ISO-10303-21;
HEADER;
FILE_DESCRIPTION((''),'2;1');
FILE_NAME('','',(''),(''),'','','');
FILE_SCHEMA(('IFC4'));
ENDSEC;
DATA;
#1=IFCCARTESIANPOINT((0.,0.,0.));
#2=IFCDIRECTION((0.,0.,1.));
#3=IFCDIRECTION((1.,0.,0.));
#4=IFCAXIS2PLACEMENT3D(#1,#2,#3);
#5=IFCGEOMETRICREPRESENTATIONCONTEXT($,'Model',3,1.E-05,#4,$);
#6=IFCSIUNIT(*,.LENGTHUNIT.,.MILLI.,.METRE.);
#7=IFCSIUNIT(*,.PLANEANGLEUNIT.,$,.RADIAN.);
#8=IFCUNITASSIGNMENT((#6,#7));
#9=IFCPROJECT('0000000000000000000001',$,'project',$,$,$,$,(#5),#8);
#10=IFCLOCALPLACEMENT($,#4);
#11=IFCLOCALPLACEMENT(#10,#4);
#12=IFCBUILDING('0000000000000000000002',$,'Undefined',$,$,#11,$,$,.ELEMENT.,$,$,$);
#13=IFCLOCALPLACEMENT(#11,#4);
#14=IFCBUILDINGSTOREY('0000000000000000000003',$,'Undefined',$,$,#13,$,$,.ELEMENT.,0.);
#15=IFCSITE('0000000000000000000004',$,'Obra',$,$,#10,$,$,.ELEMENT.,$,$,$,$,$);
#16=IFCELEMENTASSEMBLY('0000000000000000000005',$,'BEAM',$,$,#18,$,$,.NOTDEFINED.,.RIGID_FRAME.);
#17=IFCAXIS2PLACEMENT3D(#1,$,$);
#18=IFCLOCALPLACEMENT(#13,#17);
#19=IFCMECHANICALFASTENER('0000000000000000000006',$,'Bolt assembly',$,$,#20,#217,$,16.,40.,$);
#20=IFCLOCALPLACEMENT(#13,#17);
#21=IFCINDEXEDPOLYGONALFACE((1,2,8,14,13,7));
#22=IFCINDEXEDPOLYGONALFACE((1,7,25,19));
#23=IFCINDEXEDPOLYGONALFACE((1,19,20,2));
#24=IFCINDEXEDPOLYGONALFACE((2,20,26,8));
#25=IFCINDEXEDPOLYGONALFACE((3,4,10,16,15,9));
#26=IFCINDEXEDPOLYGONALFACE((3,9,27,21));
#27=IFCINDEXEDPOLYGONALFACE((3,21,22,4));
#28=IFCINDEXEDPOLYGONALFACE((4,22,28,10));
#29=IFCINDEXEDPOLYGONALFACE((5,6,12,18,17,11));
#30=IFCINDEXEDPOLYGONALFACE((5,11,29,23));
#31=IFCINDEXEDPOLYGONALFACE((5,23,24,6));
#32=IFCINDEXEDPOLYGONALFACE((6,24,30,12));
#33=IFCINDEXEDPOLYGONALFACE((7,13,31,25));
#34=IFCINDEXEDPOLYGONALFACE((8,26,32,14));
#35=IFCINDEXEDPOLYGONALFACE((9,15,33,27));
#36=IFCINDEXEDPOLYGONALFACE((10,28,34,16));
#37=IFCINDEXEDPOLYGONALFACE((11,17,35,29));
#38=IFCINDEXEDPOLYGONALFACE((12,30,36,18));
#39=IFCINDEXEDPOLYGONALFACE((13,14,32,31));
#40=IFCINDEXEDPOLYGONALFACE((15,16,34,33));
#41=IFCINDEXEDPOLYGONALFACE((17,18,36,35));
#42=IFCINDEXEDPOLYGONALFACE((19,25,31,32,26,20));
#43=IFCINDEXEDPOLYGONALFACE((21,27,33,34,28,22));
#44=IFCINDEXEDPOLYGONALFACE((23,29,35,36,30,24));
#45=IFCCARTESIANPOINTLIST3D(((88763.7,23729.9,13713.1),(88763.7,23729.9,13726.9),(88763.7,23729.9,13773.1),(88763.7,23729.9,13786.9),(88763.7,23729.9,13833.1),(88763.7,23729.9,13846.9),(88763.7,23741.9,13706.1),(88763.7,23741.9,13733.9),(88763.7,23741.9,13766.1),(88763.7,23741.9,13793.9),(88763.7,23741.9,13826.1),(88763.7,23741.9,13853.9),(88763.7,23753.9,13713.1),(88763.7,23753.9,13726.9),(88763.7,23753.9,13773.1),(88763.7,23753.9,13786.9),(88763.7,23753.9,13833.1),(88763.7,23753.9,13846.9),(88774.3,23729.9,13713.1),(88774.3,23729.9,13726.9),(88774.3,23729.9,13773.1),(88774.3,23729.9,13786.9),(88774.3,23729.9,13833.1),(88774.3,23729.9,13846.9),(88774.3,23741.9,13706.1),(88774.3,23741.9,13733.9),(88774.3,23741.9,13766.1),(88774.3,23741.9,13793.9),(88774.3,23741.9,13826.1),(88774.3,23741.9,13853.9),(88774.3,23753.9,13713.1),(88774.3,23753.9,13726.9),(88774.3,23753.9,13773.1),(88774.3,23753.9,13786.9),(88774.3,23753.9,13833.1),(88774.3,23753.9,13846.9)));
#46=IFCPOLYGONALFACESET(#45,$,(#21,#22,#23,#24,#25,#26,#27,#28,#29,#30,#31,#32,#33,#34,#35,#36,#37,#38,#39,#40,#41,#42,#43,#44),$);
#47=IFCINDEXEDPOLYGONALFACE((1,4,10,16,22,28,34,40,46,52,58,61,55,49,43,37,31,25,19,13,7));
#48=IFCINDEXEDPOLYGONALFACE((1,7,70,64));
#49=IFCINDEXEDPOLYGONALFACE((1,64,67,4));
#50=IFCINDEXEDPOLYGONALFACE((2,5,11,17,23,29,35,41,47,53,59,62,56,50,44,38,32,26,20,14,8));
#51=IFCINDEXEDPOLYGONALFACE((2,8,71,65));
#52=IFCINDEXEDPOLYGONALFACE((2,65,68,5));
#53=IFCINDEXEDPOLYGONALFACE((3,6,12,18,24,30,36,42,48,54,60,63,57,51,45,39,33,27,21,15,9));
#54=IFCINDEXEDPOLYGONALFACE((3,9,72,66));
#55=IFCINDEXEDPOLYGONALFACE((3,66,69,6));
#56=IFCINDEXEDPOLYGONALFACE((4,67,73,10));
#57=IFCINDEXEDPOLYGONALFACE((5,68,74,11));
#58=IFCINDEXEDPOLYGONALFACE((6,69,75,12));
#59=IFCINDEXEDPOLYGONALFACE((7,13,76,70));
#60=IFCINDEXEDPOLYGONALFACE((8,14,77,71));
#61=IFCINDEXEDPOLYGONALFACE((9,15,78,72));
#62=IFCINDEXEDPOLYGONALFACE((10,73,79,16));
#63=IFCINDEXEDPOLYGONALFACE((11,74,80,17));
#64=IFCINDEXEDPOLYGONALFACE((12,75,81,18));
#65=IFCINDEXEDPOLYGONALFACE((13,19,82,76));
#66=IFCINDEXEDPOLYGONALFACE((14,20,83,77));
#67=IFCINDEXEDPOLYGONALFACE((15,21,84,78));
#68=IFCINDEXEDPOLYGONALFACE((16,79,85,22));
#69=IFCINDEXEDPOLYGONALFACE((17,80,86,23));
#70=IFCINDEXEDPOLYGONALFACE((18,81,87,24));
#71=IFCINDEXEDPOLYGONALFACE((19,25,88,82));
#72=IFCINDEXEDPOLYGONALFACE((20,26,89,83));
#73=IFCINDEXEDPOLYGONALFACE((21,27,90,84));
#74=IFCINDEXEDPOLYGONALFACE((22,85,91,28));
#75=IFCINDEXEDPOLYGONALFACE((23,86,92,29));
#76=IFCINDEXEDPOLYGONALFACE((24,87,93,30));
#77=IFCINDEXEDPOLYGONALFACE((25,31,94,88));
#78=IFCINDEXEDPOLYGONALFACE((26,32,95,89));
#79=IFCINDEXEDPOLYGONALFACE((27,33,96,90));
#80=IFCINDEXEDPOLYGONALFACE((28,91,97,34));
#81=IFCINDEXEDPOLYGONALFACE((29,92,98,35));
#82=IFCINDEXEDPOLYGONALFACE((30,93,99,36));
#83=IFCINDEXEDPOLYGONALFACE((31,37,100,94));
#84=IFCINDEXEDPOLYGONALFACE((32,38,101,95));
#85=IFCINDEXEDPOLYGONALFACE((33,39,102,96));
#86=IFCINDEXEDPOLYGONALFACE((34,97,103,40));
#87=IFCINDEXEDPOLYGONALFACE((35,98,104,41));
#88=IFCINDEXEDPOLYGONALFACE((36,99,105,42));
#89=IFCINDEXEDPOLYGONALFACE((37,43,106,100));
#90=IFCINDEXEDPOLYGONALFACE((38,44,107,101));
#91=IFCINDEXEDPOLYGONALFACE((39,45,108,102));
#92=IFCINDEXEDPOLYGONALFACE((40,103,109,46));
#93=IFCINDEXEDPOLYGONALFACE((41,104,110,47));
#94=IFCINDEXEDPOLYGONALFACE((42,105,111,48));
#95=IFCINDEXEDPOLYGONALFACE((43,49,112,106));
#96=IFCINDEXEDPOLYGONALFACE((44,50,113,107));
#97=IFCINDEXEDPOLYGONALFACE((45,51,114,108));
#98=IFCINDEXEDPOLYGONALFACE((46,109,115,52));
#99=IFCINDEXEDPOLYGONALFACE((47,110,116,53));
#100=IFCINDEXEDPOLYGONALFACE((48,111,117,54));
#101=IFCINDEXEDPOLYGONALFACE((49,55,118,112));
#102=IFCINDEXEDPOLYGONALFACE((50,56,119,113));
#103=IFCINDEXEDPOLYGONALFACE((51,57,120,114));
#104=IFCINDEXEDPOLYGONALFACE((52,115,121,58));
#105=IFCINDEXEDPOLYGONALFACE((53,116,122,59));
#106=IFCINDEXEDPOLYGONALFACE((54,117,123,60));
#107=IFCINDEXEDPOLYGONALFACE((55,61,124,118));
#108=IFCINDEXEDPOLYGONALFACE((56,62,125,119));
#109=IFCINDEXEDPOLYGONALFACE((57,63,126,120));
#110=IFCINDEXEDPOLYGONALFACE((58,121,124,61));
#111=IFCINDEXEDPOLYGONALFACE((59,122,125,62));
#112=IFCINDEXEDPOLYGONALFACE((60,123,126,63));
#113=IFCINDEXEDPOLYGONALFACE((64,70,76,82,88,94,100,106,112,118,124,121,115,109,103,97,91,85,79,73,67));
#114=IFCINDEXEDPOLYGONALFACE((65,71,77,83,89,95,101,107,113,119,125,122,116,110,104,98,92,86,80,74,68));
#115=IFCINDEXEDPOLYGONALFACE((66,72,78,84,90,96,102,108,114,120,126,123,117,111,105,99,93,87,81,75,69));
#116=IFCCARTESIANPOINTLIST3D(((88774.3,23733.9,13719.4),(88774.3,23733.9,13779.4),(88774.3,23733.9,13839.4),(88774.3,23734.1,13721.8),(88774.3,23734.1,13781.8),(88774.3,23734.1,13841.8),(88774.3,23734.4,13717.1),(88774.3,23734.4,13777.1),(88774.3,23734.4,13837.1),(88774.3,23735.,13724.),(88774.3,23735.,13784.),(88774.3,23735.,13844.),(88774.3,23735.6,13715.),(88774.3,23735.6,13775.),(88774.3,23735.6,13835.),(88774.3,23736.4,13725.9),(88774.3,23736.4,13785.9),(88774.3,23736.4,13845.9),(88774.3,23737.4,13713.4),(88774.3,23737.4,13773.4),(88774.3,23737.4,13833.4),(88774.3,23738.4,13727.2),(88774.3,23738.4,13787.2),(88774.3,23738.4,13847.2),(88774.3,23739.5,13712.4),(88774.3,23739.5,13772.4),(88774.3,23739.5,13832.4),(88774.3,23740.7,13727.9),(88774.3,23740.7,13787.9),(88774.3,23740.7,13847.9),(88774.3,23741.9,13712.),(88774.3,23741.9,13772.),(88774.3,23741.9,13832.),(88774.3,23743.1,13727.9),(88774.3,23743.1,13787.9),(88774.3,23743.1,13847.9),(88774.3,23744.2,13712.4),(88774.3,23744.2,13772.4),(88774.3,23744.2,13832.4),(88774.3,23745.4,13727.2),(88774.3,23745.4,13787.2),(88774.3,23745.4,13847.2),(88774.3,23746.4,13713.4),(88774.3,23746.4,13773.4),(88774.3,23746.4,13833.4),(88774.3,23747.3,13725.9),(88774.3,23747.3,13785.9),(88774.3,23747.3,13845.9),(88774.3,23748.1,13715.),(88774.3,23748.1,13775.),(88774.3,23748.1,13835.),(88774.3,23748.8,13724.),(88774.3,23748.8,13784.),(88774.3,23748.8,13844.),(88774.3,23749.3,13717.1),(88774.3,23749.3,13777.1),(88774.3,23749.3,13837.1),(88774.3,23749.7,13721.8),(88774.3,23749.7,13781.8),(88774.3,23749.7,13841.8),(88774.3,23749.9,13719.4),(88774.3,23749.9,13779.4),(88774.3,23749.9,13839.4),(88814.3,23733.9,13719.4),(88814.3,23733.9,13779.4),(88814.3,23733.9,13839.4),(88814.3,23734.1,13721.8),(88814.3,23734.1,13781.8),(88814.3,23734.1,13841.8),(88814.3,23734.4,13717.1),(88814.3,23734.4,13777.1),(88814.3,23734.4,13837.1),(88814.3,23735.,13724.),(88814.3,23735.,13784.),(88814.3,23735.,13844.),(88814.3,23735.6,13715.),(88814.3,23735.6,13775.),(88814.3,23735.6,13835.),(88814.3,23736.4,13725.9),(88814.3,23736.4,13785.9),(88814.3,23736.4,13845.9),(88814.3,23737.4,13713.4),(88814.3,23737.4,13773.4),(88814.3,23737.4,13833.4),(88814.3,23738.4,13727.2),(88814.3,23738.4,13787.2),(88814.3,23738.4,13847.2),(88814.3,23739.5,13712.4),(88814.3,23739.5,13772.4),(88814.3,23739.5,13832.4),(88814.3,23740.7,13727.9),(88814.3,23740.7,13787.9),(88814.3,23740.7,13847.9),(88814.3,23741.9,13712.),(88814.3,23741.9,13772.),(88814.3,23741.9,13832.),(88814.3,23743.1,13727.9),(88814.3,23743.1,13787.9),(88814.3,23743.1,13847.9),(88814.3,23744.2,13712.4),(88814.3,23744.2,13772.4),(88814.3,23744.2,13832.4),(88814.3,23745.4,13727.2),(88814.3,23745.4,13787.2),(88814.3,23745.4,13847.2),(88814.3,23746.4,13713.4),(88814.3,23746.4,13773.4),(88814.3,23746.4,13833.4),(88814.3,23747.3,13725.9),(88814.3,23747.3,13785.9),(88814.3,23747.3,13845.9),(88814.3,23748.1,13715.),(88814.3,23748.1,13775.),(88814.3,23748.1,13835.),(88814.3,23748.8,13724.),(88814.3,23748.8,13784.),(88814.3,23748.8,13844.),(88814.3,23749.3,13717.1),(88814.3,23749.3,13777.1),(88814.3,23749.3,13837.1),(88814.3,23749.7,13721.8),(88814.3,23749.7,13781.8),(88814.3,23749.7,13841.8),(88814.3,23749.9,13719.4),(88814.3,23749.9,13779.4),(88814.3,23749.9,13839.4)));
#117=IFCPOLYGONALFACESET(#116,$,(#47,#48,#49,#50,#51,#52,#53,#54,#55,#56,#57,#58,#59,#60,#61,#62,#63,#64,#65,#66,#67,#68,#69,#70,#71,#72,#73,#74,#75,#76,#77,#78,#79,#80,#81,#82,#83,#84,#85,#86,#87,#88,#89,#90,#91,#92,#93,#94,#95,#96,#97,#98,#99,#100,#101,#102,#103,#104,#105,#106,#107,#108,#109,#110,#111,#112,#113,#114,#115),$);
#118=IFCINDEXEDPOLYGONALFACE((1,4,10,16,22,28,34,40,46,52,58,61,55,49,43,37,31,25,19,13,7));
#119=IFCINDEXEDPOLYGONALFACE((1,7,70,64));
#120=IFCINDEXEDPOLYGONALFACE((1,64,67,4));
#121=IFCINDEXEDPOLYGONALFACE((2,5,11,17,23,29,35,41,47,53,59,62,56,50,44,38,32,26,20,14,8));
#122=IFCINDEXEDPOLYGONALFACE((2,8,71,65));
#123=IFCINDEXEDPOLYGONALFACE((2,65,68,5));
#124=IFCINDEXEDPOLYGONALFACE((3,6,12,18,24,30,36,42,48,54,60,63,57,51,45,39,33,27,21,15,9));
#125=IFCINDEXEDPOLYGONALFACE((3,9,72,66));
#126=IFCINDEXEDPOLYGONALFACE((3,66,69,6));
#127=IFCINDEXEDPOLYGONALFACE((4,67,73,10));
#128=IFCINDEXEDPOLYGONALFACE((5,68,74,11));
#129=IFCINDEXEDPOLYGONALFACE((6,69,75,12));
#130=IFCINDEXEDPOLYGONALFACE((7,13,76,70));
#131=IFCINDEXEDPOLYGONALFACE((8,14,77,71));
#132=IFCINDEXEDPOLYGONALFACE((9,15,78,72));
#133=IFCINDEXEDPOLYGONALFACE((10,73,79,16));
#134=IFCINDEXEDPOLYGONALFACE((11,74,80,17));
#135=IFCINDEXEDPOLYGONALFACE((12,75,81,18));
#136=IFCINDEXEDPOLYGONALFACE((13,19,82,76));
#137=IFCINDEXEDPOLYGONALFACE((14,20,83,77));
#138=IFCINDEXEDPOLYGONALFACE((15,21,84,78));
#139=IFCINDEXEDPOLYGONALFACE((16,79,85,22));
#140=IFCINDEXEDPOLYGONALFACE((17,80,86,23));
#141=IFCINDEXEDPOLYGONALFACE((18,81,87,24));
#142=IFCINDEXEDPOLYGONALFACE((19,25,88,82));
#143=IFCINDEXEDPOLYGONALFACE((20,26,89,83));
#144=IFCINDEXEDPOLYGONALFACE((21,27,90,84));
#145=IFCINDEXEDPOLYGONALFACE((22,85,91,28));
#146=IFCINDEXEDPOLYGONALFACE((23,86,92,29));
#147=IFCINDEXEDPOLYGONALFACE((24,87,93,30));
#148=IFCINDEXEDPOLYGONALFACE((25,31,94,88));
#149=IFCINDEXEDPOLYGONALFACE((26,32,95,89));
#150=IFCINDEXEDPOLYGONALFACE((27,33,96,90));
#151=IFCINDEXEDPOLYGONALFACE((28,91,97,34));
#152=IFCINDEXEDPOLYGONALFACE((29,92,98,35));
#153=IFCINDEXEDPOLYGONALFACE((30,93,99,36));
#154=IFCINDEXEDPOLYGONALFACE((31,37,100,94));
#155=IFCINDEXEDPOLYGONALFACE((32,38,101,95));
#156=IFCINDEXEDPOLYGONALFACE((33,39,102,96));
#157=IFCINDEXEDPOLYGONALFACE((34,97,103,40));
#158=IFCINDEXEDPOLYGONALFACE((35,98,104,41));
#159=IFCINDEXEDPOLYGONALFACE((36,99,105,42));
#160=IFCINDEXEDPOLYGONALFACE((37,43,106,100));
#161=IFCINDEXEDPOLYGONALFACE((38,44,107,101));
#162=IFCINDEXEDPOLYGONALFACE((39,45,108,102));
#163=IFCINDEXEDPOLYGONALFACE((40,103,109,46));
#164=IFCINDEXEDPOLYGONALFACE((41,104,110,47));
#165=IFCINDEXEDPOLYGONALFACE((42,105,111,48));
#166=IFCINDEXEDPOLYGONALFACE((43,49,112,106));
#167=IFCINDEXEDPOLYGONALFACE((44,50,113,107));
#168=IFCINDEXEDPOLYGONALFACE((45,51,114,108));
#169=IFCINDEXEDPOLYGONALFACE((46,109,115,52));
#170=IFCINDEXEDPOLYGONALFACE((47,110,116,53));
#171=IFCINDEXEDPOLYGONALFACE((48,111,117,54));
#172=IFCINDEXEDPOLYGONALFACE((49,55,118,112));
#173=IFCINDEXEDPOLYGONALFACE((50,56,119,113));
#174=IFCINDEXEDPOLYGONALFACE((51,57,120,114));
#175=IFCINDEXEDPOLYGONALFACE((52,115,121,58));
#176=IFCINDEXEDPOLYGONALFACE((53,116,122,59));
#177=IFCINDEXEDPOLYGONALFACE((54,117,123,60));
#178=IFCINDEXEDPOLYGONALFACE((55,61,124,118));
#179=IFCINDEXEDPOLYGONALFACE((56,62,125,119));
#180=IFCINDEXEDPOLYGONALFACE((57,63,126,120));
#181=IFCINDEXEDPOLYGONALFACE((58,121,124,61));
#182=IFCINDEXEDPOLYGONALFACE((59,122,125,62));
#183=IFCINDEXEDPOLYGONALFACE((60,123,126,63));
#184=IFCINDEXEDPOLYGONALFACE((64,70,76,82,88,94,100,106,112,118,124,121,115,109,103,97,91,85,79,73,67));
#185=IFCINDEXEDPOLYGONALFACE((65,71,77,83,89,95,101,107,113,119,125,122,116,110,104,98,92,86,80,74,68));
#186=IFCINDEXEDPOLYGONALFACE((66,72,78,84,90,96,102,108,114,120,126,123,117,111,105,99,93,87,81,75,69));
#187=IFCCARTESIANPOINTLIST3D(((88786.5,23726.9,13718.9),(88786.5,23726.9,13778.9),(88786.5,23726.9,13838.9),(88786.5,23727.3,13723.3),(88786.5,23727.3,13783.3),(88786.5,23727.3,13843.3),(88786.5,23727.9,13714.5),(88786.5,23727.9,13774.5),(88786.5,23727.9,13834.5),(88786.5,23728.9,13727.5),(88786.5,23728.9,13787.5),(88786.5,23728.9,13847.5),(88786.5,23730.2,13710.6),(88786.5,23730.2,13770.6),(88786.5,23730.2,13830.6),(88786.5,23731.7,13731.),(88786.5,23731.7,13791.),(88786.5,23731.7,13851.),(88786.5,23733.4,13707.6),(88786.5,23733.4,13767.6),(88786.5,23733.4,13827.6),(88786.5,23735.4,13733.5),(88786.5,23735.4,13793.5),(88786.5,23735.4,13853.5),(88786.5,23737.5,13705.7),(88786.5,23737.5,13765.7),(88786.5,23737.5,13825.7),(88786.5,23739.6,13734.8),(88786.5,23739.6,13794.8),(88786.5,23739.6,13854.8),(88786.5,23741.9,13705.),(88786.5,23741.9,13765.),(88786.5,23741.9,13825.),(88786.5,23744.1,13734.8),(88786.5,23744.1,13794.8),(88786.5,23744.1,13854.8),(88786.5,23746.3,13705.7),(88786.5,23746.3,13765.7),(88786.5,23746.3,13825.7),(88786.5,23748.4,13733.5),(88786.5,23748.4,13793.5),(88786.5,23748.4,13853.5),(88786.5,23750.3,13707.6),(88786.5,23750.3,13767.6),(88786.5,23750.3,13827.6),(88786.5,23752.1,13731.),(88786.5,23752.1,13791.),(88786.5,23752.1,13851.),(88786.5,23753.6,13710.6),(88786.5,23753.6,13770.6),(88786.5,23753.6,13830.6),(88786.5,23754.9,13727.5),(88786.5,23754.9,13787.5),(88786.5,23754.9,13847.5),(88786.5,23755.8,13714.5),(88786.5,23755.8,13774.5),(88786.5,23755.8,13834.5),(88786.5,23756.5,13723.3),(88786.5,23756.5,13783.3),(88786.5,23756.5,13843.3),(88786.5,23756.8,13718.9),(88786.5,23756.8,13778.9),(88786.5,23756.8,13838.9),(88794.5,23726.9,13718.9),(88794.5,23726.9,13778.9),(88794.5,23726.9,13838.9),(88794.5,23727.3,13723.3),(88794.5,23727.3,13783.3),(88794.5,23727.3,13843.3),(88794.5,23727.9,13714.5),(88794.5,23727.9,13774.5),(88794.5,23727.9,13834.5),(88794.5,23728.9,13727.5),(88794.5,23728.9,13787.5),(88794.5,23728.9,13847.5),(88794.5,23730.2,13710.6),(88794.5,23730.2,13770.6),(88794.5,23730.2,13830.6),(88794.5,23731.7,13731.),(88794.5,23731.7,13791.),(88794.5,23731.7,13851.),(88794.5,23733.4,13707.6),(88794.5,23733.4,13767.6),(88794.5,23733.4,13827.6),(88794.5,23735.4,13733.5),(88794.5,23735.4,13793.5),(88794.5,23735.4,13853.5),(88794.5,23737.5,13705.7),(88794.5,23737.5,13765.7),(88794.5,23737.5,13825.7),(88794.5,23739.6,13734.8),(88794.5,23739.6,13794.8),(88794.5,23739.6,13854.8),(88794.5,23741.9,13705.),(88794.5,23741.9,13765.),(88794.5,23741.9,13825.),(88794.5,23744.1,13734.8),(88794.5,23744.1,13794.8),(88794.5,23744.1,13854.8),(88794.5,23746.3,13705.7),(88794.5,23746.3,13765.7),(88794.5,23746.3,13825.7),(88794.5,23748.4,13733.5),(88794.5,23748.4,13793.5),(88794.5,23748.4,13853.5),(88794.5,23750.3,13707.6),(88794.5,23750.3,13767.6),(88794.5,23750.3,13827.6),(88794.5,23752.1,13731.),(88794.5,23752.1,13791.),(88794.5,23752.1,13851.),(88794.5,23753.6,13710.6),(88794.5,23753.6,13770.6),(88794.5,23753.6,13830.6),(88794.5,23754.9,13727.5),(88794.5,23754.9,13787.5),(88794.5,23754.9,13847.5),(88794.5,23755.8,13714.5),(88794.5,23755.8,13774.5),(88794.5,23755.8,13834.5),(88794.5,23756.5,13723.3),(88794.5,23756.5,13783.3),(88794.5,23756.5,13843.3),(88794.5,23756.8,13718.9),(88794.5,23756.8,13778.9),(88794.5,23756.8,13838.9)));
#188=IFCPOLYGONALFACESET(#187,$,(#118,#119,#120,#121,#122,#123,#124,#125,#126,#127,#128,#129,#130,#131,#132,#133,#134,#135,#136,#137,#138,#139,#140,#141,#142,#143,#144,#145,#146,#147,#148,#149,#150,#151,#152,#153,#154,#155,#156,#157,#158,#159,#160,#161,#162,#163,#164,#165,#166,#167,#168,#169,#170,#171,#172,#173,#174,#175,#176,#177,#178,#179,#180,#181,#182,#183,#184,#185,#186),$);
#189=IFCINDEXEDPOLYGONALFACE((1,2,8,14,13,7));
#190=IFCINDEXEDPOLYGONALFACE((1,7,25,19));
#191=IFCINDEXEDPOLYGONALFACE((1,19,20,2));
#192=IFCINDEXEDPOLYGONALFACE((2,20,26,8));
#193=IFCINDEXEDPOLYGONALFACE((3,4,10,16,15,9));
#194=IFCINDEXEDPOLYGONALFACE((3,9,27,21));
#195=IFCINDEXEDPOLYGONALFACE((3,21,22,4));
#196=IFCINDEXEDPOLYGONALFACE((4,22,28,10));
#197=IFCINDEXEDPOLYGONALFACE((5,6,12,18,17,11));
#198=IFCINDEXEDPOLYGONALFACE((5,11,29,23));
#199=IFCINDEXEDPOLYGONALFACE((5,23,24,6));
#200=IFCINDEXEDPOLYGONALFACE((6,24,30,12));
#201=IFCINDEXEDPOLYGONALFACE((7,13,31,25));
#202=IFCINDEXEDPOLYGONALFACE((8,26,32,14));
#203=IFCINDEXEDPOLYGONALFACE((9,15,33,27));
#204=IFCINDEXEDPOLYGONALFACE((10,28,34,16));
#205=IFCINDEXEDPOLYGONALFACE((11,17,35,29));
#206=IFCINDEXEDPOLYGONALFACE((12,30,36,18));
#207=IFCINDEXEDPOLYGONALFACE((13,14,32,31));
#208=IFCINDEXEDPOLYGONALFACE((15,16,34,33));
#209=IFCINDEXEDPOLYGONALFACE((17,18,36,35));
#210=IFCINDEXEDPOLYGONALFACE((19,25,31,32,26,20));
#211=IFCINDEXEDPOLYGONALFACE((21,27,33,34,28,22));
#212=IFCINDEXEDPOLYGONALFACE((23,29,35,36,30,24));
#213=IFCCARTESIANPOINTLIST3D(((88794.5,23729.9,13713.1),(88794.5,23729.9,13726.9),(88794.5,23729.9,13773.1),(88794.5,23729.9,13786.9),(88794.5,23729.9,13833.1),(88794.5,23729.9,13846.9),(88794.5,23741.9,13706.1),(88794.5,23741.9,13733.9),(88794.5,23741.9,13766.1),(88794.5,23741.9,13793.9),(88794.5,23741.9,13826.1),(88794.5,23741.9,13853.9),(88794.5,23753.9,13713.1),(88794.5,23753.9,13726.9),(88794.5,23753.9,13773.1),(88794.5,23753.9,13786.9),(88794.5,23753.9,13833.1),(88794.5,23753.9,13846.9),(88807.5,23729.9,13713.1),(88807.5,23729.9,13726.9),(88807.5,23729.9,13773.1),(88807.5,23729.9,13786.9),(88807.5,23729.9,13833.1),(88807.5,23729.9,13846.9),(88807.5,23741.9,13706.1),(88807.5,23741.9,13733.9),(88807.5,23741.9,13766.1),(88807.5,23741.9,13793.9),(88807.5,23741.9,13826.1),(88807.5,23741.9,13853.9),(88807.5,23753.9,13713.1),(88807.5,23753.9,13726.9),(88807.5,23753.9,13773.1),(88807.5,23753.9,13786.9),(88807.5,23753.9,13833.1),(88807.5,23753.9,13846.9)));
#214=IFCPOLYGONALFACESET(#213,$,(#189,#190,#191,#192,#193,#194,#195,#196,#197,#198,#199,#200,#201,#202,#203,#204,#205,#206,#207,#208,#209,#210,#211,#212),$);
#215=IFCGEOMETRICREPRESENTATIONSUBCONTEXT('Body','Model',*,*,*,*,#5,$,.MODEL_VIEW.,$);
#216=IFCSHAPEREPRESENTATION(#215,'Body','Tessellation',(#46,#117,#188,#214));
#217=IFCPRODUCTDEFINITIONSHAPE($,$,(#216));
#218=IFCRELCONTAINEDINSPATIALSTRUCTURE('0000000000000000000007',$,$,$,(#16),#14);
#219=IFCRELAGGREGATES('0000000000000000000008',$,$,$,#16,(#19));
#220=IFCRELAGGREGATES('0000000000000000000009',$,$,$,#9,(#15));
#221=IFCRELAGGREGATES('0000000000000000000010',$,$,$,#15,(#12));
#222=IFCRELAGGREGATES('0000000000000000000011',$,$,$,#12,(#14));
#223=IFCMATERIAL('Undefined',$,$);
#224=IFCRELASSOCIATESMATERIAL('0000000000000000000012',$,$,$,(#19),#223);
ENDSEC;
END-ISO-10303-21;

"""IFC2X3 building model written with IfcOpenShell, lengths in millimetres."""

from ifc_helpers import new_model, si_unit, frame, origin_with_axes, origin_2d_with_axis, place, context, subcontext, project, spatial, polyline, circle, outline, extrude, source, transform, mapped, material, element, aggregate, save


model = new_model("IFC2X3")

# Units and contexts
model_context = context("Model", 3, precision=1e-05, world=origin_with_axes())
body_context = subcontext(model_context, "Body", "Model", "MODEL_VIEW")
ifc_project = project(units=[si_unit("LENGTHUNIT", "METRE", prefix="MILLI"), si_unit("PLANEANGLEUNIT", "RADIAN")], contexts=[model_context])

# Site, building, storey
site_placement = place(None, origin_with_axes())
site = spatial("IfcSite", under=ifc_project, at=site_placement, Name="Obra", CompositionType="ELEMENT")
building_placement = place(site_placement, origin_with_axes())
building = spatial("IfcBuilding", under=site, at=building_placement, Name="Undefined", CompositionType="ELEMENT")
storey_placement = place(building_placement, origin_with_axes())
storey = spatial("IfcBuildingStorey", under=building, at=storey_placement, Name="Undefined", CompositionType="ELEMENT", Elevation=0.0)

# Shared definitions
ifc_material_1 = material(Name="Undefined")
shared_shape_1 = source(origin_with_axes(), body_context, "Body", "SweptSolid", [
    extrude(outline(polyline([(13.9, 0.0), (6.9, 12.0), (-6.9, 12.0), (-13.9, 0.0), (-6.9, -12.0), (6.9, -12.0), (13.9, 0.0)])), frame((0.0, -19.7, 0.0), z_axis=(0.0, 1.0, 0.0), x_axis=(1.0, 0.0, 0.0)), (0.0, 0.0, 1.0), 10.6),
    extrude(circle(Radius=8.0, at=origin_2d_with_axis()), frame((0.0, -9.1, 0.0), z_axis=(0.0, 1.0, 0.0), x_axis=(1.0, 0.0, 0.0)), (0.0, 0.0, 1.0), 40.0),
    extrude(circle(Radius=15.0, at=origin_2d_with_axis()), frame((0.0, 3.1, 0.0), z_axis=(0.0, 1.0, 0.0), x_axis=(1.0, 0.0, 0.0)), (0.0, 0.0, 1.0), 8.0),
    extrude(outline(polyline([(13.9, 0.0), (6.9, 12.0), (-6.9, 12.0), (-13.9, 0.0), (-6.9, -12.0), (6.9, -12.0), (13.9, 0.0)])), frame((0.0, 11.1, 0.0), z_axis=(0.0, 1.0, 0.0), x_axis=(1.0, 0.0, 0.0)), (0.0, 0.0, 1.0), 13.0),
])

# Element assembly, mechanical fastener
assembly_1_placement = place(storey_placement, origin_with_axes())
assembly_1 = element("IfcElementAssembly", 1, at=assembly_1_placement, inside=storey, Name="BEAM", AssemblyPlace="NOTDEFINED", PredefinedType="RIGID_FRAME")
mechanical_fastener_1_placement = place(assembly_1_placement, frame((88783.4, 23791.9, 13885.4), z_axis=(0.0, -1.0, 0.0), x_axis=(0.0, 0.0, -1.0)))
mechanical_fastener_1 = element("IfcMechanicalFastener", 2, at=mechanical_fastener_1_placement, material=ifc_material_1, Name="Bolt assembly", NominalDiameter=16.0, NominalLength=40.0, context=body_context, shape_type="MappedRepresentation", body=[
    mapped(shared_shape_1, transform((165.4, 0.0, 50.0))),
    mapped(shared_shape_1, transform((105.4, 0.0, 50.0))),
    mapped(shared_shape_1, transform((45.4, 0.0, 50.0))),
])
aggregate(assembly_1, [mechanical_fastener_1])

save(model, "model.ifc")
